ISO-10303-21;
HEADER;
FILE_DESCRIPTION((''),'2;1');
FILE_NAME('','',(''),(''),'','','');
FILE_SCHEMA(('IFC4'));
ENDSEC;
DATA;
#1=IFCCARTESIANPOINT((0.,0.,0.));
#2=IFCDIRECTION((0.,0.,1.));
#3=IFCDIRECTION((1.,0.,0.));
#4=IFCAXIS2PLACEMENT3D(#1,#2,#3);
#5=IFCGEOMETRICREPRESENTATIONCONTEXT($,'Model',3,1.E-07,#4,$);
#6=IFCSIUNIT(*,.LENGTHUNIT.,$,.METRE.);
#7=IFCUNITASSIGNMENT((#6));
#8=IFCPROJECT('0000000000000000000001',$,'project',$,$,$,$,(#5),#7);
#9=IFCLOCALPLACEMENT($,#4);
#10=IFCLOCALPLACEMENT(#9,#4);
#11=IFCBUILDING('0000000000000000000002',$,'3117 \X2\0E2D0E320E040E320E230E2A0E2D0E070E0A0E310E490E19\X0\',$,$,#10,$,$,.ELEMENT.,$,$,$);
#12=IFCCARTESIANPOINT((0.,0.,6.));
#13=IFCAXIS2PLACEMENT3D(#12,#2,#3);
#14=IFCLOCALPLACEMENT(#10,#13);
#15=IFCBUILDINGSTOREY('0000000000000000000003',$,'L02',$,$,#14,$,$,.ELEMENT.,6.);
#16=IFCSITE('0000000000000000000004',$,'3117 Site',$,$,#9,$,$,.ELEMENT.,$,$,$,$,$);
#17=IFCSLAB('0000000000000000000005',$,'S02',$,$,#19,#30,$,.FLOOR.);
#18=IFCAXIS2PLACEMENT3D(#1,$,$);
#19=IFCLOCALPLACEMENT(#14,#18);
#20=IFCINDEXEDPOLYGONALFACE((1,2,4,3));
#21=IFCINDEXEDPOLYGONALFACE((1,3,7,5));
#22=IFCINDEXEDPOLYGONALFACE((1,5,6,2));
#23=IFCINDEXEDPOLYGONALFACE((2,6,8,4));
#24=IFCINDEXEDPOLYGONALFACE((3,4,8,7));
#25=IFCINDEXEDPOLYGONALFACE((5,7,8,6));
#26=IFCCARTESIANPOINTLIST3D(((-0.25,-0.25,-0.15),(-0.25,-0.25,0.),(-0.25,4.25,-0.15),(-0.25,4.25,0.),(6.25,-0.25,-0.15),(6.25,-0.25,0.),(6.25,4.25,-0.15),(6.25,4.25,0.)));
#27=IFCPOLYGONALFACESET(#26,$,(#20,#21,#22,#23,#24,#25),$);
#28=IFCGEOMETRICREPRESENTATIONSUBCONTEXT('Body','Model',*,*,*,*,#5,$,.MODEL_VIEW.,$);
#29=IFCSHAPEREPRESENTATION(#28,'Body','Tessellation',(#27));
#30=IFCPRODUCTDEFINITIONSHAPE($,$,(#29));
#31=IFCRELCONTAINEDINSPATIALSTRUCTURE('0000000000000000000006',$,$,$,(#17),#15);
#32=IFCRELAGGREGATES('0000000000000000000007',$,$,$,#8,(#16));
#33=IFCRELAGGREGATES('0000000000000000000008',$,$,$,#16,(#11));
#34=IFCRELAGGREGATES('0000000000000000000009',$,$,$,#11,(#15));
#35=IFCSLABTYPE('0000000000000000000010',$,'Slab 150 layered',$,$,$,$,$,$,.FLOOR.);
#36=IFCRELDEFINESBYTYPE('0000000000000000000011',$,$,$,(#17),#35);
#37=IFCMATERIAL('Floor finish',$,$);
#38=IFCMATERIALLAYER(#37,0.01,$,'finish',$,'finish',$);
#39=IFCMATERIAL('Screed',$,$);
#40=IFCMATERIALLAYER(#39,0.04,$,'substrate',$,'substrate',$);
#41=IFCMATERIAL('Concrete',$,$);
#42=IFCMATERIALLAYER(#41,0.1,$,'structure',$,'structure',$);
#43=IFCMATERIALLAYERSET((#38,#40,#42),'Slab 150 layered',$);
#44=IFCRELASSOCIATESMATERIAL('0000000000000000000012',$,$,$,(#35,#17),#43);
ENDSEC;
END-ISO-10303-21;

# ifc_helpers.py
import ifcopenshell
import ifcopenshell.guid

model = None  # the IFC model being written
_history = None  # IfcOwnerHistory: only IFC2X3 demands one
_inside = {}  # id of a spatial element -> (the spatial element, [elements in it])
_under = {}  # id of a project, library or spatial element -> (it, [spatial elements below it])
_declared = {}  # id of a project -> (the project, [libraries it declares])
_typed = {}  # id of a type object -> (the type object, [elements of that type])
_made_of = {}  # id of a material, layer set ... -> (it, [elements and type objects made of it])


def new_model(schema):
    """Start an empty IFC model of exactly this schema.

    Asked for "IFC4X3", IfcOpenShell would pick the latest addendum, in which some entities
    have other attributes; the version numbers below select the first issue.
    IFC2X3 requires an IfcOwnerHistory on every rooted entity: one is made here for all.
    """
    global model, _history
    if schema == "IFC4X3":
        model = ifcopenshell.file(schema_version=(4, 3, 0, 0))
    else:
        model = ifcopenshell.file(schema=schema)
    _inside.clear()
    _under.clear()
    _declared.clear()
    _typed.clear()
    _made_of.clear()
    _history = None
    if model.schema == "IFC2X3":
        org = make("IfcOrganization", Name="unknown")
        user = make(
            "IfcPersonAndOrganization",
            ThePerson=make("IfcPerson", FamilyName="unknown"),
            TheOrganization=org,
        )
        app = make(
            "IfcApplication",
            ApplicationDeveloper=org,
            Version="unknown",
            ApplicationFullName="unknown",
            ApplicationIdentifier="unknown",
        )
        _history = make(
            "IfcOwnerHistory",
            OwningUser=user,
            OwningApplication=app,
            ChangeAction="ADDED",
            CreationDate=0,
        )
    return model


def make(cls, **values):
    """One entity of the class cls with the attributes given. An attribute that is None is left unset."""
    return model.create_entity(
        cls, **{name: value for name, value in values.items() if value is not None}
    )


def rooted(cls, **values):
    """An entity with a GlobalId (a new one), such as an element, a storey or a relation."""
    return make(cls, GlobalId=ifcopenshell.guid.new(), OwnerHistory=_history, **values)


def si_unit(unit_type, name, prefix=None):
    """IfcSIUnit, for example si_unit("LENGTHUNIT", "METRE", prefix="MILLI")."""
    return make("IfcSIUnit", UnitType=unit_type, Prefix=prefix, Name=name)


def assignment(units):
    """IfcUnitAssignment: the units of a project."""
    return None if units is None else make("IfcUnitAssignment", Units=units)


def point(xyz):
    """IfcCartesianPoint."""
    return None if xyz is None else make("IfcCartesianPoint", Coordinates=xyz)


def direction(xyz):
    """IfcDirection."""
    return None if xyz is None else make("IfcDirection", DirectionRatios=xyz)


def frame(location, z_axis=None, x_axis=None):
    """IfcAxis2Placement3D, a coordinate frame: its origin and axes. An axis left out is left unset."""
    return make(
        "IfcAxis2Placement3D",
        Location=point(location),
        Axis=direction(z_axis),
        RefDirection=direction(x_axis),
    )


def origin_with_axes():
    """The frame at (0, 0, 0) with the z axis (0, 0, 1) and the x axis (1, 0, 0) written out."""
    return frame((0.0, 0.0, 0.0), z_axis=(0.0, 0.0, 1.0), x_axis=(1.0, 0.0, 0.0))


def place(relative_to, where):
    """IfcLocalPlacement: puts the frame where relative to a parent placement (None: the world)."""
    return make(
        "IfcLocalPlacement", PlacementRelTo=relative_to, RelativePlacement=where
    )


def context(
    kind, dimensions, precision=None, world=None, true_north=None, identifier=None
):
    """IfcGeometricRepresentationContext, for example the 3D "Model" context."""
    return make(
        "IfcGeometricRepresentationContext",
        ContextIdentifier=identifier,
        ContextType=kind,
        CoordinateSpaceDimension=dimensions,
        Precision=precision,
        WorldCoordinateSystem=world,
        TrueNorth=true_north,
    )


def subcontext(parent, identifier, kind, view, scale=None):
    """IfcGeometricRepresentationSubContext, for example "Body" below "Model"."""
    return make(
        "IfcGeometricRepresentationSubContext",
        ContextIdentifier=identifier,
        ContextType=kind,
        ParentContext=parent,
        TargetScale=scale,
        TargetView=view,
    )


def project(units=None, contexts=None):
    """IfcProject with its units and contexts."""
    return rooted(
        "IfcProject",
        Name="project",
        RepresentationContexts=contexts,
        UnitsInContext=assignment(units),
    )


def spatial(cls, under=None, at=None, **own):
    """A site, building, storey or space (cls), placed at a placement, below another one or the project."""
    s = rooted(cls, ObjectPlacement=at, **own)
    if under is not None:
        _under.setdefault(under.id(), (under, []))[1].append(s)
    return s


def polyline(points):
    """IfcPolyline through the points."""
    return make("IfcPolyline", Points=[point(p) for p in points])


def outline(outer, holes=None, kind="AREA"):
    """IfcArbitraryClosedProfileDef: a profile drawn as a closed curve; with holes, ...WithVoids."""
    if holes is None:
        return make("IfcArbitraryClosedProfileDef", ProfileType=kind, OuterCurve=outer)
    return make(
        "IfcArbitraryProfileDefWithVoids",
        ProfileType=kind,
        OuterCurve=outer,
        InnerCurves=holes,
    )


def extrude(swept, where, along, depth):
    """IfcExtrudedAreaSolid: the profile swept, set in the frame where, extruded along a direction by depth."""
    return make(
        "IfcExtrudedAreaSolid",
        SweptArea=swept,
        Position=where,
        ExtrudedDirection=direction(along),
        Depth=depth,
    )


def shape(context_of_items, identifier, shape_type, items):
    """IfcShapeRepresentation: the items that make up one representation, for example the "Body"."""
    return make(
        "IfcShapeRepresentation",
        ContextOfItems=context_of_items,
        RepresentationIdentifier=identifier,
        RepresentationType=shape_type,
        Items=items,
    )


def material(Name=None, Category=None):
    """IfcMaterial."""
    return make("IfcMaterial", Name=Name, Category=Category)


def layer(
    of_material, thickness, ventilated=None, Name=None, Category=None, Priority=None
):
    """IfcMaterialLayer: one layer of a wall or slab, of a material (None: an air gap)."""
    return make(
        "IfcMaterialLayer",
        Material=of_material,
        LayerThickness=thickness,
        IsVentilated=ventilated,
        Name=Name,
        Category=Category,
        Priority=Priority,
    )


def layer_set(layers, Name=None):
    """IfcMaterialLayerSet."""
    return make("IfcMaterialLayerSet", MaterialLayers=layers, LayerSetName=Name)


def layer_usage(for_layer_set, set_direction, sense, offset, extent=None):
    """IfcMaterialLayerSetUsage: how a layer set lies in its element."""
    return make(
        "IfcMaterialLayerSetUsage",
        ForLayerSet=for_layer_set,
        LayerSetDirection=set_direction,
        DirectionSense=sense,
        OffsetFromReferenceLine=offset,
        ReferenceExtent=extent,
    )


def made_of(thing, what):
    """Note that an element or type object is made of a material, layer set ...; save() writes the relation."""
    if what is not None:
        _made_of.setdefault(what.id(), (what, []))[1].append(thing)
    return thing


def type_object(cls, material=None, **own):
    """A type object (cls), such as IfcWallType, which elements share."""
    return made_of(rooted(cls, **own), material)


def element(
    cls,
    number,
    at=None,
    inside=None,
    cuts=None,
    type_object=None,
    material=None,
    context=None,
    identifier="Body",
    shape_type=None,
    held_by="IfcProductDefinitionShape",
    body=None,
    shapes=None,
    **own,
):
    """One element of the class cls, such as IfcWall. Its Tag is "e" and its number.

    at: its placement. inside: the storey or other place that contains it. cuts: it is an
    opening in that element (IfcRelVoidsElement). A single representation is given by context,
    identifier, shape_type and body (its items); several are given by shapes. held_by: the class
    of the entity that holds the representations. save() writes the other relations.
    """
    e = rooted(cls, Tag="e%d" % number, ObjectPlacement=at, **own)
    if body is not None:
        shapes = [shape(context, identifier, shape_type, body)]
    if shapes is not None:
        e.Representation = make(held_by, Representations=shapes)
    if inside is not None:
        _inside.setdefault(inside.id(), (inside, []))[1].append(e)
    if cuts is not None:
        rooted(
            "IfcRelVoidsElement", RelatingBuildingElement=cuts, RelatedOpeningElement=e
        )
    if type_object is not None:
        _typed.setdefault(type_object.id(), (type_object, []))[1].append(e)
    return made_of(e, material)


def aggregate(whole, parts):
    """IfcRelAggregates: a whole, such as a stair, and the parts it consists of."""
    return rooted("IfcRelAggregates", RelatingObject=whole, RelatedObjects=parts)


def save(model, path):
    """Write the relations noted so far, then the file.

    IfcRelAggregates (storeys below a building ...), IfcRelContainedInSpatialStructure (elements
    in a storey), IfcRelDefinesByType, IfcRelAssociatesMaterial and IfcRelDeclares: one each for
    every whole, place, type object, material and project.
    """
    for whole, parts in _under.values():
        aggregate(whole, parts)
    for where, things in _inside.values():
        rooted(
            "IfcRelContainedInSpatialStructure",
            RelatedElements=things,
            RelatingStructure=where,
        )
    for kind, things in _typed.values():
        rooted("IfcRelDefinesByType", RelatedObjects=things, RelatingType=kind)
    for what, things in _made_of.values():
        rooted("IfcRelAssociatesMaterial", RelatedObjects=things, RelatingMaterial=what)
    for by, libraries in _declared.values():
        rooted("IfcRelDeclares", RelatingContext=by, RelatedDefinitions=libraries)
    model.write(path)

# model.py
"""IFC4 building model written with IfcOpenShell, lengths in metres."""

from ifc_helpers import new_model, si_unit, frame, origin_with_axes, place, context, subcontext, project, spatial, polyline, outline, extrude, material, layer, layer_set, layer_usage, type_object, element, save


model = new_model("IFC4")

# Units and contexts
model_context = context("Model", 3, precision=1e-07, world=origin_with_axes())
body_context = subcontext(model_context, "Body", "Model", "MODEL_VIEW")
ifc_project = project(units=[si_unit("LENGTHUNIT", "METRE")], contexts=[model_context])

# Site, building, storey
site_placement = place(None, origin_with_axes())
site = spatial("IfcSite", under=ifc_project, at=site_placement, Name="3117 Site", CompositionType="ELEMENT")
building_placement = place(site_placement, origin_with_axes())
building = spatial("IfcBuilding", under=site, at=building_placement, Name="3117 อาคารสองชั้น", CompositionType="ELEMENT")
storey_placement = place(building_placement, frame((0.0, 0.0, 6.0), z_axis=(0.0, 0.0, 1.0), x_axis=(1.0, 0.0, 0.0)))
storey = spatial("IfcBuildingStorey", under=building, at=storey_placement, Name="L02", CompositionType="ELEMENT", Elevation=6.0)

# Shared definitions
ifc_material_1 = material(Name="Concrete")

# Slab
ifc_material_2 = material(Name="Floor finish")
ifc_layer_1 = layer(ifc_material_2, 0.01, Name="finish", Category="finish")
ifc_material_3 = material(Name="Screed")
ifc_layer_2 = layer(ifc_material_3, 0.04, Name="substrate", Category="substrate")
ifc_layer_3 = layer(ifc_material_1, 0.1, Name="structure", Category="structure")
ifc_layer_set = layer_set([ifc_layer_1, ifc_layer_2, ifc_layer_3], Name="Slab 150 layered")
ifc_layer_usage = layer_usage(ifc_layer_set, "AXIS3", "NEGATIVE", 0.15)
slab_type = type_object("IfcSlabType", Name="Slab 150 layered", PredefinedType="FLOOR", material=ifc_layer_set)
slab_placement = place(storey_placement, frame((0.0, 0.0, -0.15), z_axis=(0.0, 0.0, 1.0), x_axis=(1.0, 0.0, 0.0)))
element("IfcSlab", 1, at=slab_placement, inside=storey, type_object=slab_type, material=ifc_layer_usage, Name="S02", PredefinedType="FLOOR", context=body_context, shape_type="SweptSolid", body=[
    extrude(outline(polyline([(-0.25, -0.25), (6.25, -0.25), (6.25, 4.25), (-0.25, 4.25), (-0.25, -0.25)])), origin_with_axes(), (0.0, 0.0, 1.0), 0.15),
])

save(model, "model.ifc")
